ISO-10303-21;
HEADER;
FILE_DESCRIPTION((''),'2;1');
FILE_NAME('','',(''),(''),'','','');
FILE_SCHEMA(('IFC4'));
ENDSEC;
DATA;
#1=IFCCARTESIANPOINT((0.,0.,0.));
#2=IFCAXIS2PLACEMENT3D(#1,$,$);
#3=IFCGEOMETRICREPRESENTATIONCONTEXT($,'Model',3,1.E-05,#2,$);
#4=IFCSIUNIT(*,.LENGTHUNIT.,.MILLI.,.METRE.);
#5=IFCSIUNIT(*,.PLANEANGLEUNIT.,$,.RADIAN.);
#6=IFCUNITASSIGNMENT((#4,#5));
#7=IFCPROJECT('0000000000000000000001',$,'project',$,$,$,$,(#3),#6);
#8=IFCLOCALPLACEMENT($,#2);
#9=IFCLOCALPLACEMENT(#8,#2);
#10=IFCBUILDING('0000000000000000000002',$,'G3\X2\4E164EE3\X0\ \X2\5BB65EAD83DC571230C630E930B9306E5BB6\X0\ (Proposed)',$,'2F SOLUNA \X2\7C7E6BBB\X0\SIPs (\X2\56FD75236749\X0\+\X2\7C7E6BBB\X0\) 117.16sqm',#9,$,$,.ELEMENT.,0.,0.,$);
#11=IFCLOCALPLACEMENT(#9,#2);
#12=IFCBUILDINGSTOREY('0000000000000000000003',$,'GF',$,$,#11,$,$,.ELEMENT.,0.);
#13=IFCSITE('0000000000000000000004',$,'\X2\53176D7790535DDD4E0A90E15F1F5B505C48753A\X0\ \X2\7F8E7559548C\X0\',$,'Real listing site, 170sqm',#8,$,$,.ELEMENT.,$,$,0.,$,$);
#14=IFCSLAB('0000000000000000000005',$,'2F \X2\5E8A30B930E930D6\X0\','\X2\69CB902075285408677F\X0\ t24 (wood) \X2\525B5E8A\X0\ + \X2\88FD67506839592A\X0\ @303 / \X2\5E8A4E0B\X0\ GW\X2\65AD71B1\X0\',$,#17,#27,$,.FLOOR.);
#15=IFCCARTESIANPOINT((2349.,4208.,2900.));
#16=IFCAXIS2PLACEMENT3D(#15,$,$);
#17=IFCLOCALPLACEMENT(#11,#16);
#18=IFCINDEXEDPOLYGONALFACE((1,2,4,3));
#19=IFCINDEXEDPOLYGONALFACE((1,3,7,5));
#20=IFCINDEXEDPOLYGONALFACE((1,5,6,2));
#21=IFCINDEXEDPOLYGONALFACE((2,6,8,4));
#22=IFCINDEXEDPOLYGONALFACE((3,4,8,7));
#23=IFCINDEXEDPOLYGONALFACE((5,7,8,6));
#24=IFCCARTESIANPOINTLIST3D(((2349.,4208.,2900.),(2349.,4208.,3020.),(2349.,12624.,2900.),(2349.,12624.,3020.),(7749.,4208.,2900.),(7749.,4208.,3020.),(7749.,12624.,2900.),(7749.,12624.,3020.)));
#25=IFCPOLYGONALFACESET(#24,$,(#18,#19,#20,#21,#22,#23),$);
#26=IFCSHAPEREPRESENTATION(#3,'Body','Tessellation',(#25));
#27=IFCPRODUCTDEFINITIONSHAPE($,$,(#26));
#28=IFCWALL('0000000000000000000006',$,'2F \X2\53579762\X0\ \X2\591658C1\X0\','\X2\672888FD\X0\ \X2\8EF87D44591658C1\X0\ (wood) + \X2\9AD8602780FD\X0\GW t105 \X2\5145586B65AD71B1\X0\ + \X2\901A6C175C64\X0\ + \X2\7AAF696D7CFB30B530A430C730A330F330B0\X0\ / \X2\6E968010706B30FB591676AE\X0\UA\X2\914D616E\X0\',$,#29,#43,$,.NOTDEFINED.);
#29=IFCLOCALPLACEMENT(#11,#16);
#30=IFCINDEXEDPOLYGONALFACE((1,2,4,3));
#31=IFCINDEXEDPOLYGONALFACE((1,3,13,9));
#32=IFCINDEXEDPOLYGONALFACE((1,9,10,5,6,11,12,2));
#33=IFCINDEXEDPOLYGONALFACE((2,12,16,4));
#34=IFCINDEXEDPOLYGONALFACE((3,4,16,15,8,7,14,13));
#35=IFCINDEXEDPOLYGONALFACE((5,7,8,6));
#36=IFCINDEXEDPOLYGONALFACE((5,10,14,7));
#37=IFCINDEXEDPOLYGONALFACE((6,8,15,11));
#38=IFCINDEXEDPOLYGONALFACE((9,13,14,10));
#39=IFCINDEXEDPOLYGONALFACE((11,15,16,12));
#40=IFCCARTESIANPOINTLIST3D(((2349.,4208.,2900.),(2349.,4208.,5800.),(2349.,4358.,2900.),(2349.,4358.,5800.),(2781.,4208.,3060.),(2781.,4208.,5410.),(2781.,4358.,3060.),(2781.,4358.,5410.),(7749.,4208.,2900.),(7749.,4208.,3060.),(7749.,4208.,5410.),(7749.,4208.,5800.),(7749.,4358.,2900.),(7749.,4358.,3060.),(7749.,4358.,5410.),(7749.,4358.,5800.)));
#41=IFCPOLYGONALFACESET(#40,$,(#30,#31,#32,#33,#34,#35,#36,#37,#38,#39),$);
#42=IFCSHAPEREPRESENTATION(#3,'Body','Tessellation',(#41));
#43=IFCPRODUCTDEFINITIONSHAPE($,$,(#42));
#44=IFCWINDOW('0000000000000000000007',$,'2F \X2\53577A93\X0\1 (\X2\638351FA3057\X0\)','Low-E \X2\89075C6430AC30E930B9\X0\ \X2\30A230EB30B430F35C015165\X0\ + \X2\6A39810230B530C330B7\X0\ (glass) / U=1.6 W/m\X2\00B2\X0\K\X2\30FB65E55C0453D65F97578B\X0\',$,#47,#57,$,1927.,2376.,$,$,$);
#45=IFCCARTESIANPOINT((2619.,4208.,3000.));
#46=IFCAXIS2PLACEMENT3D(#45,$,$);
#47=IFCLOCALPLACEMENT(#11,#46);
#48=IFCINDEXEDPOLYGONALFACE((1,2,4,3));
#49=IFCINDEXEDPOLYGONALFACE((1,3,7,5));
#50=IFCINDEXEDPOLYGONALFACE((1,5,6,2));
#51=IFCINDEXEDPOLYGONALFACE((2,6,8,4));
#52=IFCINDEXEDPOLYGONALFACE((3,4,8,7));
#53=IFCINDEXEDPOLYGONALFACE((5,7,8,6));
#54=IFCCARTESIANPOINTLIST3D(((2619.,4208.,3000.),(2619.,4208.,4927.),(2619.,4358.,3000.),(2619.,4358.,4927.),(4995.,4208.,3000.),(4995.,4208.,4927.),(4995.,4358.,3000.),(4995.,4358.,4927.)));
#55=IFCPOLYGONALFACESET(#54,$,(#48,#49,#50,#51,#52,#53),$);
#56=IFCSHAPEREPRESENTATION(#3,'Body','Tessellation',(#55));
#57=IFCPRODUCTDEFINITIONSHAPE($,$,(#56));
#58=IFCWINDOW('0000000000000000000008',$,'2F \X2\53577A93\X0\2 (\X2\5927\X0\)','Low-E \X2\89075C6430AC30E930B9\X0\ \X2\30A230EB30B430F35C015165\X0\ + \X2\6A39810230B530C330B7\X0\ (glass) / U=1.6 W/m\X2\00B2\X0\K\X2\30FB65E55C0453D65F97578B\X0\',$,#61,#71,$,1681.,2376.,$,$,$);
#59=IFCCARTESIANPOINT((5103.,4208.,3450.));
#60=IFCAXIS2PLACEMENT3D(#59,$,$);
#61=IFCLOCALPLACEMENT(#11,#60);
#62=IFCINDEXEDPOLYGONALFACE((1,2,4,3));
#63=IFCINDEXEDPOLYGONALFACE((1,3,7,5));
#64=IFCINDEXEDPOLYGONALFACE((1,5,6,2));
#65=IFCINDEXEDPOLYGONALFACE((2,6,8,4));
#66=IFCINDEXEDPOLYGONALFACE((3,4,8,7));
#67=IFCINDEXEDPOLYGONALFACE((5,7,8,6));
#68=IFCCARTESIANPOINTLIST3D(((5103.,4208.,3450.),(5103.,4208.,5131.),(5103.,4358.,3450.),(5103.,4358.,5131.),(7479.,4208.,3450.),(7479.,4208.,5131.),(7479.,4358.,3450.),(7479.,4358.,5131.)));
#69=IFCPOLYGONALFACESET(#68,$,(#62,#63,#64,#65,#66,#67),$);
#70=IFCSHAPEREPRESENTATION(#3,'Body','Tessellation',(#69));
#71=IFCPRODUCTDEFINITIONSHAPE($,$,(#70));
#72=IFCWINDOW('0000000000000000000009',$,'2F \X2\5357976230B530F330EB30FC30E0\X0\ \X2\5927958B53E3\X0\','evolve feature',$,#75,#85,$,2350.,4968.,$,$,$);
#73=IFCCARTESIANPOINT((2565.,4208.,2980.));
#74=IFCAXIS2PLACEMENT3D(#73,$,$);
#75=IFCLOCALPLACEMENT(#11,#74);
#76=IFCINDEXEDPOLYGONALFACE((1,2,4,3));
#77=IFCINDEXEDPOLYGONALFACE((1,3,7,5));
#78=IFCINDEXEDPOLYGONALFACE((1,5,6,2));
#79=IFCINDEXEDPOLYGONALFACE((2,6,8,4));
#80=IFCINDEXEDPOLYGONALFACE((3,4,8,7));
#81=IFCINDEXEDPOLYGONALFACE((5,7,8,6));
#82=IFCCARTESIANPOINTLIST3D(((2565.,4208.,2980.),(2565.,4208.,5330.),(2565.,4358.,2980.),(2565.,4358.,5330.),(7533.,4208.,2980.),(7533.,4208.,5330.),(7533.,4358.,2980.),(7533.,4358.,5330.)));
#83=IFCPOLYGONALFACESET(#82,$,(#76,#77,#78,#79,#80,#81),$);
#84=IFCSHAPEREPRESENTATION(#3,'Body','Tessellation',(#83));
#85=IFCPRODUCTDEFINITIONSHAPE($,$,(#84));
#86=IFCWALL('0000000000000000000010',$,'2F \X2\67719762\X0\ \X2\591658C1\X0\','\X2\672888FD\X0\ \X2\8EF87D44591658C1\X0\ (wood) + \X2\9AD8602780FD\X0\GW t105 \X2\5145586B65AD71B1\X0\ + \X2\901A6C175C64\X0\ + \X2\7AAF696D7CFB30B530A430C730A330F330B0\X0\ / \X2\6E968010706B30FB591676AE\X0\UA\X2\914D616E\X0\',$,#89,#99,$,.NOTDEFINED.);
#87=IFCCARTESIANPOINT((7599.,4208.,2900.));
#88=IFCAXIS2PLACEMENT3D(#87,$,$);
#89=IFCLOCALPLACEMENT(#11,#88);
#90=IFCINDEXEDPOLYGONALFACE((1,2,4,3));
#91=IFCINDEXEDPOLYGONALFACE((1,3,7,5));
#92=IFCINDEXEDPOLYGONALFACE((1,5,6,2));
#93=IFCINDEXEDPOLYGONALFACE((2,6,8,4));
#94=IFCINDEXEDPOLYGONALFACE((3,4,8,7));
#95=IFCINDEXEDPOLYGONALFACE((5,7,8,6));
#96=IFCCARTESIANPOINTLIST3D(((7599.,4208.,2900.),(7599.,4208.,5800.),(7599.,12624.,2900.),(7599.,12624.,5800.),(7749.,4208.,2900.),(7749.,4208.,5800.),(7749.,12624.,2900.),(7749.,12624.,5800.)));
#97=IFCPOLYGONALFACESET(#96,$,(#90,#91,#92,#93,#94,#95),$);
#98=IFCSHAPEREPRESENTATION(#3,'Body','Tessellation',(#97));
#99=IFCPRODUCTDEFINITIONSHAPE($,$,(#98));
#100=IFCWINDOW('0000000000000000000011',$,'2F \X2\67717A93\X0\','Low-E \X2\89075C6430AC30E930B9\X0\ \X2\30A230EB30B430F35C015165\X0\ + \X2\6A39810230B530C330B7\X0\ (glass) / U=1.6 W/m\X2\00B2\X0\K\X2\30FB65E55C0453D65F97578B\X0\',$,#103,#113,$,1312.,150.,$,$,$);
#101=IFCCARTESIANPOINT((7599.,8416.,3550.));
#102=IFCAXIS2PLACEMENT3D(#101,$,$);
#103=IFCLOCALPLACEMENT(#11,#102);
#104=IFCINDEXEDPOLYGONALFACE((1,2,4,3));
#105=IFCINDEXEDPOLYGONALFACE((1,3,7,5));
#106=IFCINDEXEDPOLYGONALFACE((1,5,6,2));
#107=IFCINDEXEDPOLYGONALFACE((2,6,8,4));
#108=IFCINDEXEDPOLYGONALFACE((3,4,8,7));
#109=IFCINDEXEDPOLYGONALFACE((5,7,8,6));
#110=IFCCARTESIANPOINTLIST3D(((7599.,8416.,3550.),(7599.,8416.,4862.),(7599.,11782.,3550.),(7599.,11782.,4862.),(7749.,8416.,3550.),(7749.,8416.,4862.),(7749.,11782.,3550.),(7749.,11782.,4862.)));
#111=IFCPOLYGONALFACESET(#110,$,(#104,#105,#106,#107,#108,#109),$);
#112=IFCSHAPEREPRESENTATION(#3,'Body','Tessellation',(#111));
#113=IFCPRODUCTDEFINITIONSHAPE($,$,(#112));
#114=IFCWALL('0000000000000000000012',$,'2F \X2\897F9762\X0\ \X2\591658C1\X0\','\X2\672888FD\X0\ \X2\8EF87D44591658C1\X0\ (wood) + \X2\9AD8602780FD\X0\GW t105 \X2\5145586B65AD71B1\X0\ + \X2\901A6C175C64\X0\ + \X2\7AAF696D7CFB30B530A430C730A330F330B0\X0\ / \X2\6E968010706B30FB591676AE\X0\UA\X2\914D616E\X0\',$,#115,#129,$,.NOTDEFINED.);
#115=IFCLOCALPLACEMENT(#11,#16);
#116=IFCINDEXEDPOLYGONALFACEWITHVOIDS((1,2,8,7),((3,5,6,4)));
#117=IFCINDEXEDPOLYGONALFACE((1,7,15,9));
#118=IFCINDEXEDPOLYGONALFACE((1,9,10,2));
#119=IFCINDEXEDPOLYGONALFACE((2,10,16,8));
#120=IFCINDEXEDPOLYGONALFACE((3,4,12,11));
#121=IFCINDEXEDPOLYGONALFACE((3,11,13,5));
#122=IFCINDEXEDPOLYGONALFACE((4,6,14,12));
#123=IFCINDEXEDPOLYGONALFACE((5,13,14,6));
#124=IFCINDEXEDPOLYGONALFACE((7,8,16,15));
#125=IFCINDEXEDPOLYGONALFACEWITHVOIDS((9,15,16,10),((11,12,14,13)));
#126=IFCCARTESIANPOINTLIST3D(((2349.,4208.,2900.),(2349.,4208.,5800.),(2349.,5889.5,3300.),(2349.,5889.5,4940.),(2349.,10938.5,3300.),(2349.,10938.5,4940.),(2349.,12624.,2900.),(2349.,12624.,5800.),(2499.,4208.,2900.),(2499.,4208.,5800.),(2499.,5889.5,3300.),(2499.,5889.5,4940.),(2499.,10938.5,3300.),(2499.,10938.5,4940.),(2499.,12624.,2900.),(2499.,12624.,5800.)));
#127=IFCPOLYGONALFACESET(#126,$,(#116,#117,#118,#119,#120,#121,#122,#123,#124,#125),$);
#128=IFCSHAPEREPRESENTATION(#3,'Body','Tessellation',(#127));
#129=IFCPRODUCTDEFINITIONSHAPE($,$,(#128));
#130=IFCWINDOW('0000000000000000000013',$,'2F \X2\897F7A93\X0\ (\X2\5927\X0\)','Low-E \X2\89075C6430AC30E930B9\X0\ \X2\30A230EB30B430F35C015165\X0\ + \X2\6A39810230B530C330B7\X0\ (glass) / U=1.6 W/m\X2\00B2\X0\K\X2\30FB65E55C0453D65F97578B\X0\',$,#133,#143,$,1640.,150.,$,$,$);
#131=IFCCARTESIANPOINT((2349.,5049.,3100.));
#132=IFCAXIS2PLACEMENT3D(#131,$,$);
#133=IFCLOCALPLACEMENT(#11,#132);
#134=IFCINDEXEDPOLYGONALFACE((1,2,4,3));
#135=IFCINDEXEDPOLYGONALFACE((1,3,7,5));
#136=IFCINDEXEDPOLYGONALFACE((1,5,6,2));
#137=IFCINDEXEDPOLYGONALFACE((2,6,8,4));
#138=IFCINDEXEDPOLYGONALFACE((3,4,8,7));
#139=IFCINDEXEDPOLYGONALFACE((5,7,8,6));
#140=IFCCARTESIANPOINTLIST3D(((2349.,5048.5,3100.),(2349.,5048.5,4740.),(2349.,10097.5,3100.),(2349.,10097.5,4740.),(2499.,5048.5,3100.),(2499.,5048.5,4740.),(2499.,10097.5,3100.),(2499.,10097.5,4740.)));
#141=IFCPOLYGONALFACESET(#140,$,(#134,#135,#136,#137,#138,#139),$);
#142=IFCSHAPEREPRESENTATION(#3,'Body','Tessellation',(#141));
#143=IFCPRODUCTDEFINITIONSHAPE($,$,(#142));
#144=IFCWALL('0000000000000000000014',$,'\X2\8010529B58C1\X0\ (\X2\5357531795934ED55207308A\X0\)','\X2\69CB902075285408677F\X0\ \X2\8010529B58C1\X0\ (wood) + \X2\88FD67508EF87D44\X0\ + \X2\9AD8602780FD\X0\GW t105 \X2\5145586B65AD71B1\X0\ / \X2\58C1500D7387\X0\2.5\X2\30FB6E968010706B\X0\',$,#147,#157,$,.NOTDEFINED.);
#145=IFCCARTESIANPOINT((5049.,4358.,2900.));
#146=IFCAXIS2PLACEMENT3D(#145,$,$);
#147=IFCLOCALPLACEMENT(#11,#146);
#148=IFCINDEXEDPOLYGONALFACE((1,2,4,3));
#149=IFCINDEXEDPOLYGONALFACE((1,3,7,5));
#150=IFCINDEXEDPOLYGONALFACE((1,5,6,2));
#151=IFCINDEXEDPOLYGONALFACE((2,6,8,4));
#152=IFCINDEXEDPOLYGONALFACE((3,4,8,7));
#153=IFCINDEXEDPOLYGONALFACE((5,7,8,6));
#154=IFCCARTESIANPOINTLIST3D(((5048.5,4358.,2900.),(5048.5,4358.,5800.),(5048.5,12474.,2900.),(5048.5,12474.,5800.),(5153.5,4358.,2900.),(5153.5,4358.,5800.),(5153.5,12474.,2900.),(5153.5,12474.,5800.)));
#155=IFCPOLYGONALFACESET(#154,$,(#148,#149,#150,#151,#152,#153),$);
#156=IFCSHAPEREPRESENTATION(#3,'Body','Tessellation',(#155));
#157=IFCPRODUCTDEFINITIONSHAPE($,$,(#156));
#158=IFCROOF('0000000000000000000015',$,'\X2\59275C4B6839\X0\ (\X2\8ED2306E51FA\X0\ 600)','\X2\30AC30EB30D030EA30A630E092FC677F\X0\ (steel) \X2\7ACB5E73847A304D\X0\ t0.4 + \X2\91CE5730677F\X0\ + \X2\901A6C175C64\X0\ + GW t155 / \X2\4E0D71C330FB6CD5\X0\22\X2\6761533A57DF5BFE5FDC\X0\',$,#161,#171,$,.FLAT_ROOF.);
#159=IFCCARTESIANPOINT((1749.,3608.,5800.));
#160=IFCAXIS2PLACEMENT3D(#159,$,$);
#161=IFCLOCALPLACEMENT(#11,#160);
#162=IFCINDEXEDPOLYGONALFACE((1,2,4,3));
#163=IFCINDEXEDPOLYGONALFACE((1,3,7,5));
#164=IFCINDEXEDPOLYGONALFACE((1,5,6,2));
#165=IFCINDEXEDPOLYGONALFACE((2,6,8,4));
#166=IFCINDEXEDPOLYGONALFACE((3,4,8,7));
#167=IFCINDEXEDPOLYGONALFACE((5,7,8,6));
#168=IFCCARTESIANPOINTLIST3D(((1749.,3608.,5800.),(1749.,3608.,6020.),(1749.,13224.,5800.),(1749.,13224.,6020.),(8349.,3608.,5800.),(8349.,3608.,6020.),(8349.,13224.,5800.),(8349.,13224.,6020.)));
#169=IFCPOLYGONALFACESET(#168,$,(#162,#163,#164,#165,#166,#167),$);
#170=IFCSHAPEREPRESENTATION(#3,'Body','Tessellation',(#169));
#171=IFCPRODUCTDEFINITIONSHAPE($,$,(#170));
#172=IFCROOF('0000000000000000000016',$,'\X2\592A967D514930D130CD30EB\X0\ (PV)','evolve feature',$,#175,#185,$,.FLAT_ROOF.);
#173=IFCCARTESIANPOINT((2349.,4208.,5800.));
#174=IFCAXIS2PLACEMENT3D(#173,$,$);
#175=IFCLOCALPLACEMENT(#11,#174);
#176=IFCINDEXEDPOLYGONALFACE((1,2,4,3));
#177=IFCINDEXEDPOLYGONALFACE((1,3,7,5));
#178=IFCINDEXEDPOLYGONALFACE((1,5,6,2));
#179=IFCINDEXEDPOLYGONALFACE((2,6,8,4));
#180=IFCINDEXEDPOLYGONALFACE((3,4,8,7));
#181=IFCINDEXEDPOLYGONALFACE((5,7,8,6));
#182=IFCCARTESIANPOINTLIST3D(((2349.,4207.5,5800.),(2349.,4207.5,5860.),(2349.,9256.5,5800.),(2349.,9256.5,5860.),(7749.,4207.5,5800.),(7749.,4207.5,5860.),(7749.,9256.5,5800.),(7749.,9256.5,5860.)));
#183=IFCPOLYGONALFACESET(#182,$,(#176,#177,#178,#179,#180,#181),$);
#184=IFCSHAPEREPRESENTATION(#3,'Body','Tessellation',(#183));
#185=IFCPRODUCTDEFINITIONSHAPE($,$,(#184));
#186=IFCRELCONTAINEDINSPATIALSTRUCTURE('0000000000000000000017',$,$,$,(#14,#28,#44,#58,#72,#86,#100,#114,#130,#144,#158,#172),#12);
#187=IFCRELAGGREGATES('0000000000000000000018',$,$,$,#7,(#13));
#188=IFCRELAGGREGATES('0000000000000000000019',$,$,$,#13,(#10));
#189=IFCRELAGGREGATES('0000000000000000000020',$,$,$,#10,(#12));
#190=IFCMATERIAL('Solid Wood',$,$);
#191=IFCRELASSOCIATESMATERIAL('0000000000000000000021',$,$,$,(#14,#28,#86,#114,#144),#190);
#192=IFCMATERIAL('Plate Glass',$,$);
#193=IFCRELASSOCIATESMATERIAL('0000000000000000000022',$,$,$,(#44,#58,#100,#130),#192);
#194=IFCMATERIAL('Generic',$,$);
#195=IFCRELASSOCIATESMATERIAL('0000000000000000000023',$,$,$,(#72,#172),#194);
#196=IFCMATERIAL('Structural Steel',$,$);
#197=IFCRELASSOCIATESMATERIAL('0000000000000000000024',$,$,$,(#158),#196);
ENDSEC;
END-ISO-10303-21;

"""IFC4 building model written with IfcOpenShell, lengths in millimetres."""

from ifc_helpers import new_model, si_unit, frame, frame_2d, origin, place, context, project, spatial, rectangle, extrude, material, element, fill, save


model = new_model("IFC4")

# Units and contexts
model_context = context("Model", 3, precision=1e-05, world=origin())
ifc_project = project(units=[si_unit("LENGTHUNIT", "METRE", prefix="MILLI"), si_unit("PLANEANGLEUNIT", "RADIAN")], contexts=[model_context])

# Site, building, storey
site_placement = place(None, origin())
site = spatial("IfcSite", under=ifc_project, at=site_placement, Name="北海道川上郡弟子屈町 美留和", ObjectType="Real listing site, 170sqm", CompositionType="ELEMENT", RefElevation=0.0)
building_placement = place(site_placement, origin())
building = spatial("IfcBuilding", under=site, at=building_placement, Name="G3世代 家庭菜園テラスの家 (Proposed)", ObjectType="2F SOLUNA 籾殻SIPs (国産杉+籾殻) 117.16sqm", CompositionType="ELEMENT", ElevationOfRefHeight=0.0, ElevationOfTerrain=0.0)
storey_placement = place(building_placement, origin())
storey = spatial("IfcBuildingStorey", under=building, at=storey_placement, Name="GF", CompositionType="ELEMENT", Elevation=0.0)

# Slab
ifc_material_1 = material(Name="Solid Wood")
slab_placement = place(storey_placement, frame((2349.0, 4208.0, 2900.0)))
element("IfcSlab", 1, at=slab_placement, inside=storey, material=ifc_material_1, Name="2F 床スラブ", Description="構造用合板 t24 (wood) 剛床 + 製材根太 @303 / 床下 GW断熱", PredefinedType="FLOOR", context=model_context, shape_type="SweptSolid", body=[
    extrude(rectangle(XDim=5400.0, YDim=8416.0, at=frame_2d((2700.0, 4208.0))), frame((2349.0, 4208.0, 2900.0)), (0.0, 0.0, 1.0), 120.0),
])

# Wall, openings, windows
wall_1_placement = place(storey_placement, frame((2349.0, 4208.0, 2900.0)))
wall_1 = element("IfcWall", 2, at=wall_1_placement, inside=storey, material=ifc_material_1, Name="2F 南面 外壁", Description="木製 軸組外壁 (wood) + 高性能GW t105 充填断熱 + 通気層 + 窯業系サイディング / 準耐火・外皮UA配慮", PredefinedType="NOTDEFINED", context=model_context, shape_type="SweptSolid", body=[
    extrude(rectangle(XDim=5400.0, YDim=150.0, at=frame_2d((2700.0, 75.0))), frame((2349.0, 4208.0, 2900.0)), (0.0, 0.0, 1.0), 2900.0),
])
opening_1_placement = place(storey_placement, frame((2619.0, 4208.0, 3000.0)))
opening_1 = element("IfcOpeningElement", 3, at=opening_1_placement, cuts=wall_1, PredefinedType="NOTDEFINED", context=model_context, shape_type="SweptSolid", body=[
    extrude(rectangle(XDim=2376.0, YDim=150.0, at=frame_2d((1188.0, 75.0))), frame((2619.0, 4208.0, 3000.0)), (0.0, 0.0, 1.0), 1927.0),
])
opening_2_placement = place(storey_placement, frame((5103.0, 4208.0, 3450.0)))
opening_2 = element("IfcOpeningElement", 4, at=opening_2_placement, cuts=wall_1, PredefinedType="NOTDEFINED", context=model_context, shape_type="SweptSolid", body=[
    extrude(rectangle(XDim=2376.0, YDim=150.0, at=frame_2d((1188.0, 75.0))), frame((5103.0, 4208.0, 3450.0)), (0.0, 0.0, 1.0), 1681.0),
])
opening_3_placement = place(storey_placement, frame((2565.0, 4208.0, 2980.0)))
opening_3 = element("IfcOpeningElement", 5, at=opening_3_placement, cuts=wall_1, PredefinedType="NOTDEFINED", context=model_context, shape_type="SweptSolid", body=[
    extrude(rectangle(XDim=4968.0, YDim=150.0, at=frame_2d((2484.0, 75.0))), frame((2565.0, 4208.0, 2980.0)), (0.0, 0.0, 1.0), 2350.0),
])
ifc_material_2 = material(Name="Plate Glass")
window_1_placement = place(storey_placement, frame((2619.0, 4208.0, 3000.0)))
window_1 = element("IfcWindow", 6, at=window_1_placement, inside=storey, material=ifc_material_2, Name="2F 南窓1 (掃出し)", Description="Low-E 複層ガラス アルゴン封入 + 樹脂サッシ (glass) / U=1.6 W/m²K・日射取得型", OverallHeight=1927.0, OverallWidth=2376.0, context=model_context, shape_type="SweptSolid", body=[
    extrude(rectangle(XDim=2376.0, YDim=150.0, at=frame_2d((1188.0, 75.0))), frame((2619.0, 4208.0, 3000.0)), (0.0, 0.0, 1.0), 1927.0),
])
fill(opening_1, window_1)
window_2_placement = place(storey_placement, frame((5103.0, 4208.0, 3450.0)))
window_2 = element("IfcWindow", 7, at=window_2_placement, inside=storey, material=ifc_material_2, Name="2F 南窓2 (大)", Description="Low-E 複層ガラス アルゴン封入 + 樹脂サッシ (glass) / U=1.6 W/m²K・日射取得型", OverallHeight=1681.0, OverallWidth=2376.0, context=model_context, shape_type="SweptSolid", body=[
    extrude(rectangle(XDim=2376.0, YDim=150.0, at=frame_2d((1188.0, 75.0))), frame((5103.0, 4208.0, 3450.0)), (0.0, 0.0, 1.0), 1681.0),
])
fill(opening_2, window_2)
ifc_material_3 = material(Name="Generic")
window_3_placement = place(storey_placement, frame((2565.0, 4208.0, 2980.0)))
window_3 = element("IfcWindow", 8, at=window_3_placement, inside=storey, material=ifc_material_3, Name="2F 南面サンルーム 大開口", Description="evolve feature", OverallHeight=2350.0, OverallWidth=4968.0, context=model_context, shape_type="SweptSolid", body=[
    extrude(rectangle(XDim=4968.0, YDim=150.0, at=frame_2d((2484.0, 75.0))), frame((2565.0, 4208.0, 2980.0)), (0.0, 0.0, 1.0), 2350.0),
])
fill(opening_3, window_3)

# Walls, openings, windows
wall_2_placement = place(storey_placement, frame((7599.0, 4208.0, 2900.0)))
wall_2 = element("IfcWall", 9, at=wall_2_placement, inside=storey, material=ifc_material_1, Name="2F 東面 外壁", Description="木製 軸組外壁 (wood) + 高性能GW t105 充填断熱 + 通気層 + 窯業系サイディング / 準耐火・外皮UA配慮", PredefinedType="NOTDEFINED", context=model_context, shape_type="SweptSolid", body=[
    extrude(rectangle(XDim=150.0, YDim=8416.0, at=frame_2d((75.0, 4208.0))), frame((7599.0, 4208.0, 2900.0)), (0.0, 0.0, 1.0), 2900.0),
])
opening_4_placement = place(storey_placement, frame((7599.0, 8416.0, 3550.0)))
opening_4 = element("IfcOpeningElement", 10, at=opening_4_placement, cuts=wall_2, PredefinedType="NOTDEFINED", context=model_context, shape_type="SweptSolid", body=[
    extrude(rectangle(XDim=150.0, YDim=3366.0, at=frame_2d((75.0, 1683.0))), frame((7599.0, 8416.0, 3550.0)), (0.0, 0.0, 1.0), 1312.0),
])
window_4_placement = place(storey_placement, frame((7599.0, 8416.0, 3550.0)))
window_4 = element("IfcWindow", 11, at=window_4_placement, inside=storey, material=ifc_material_2, Name="2F 東窓", Description="Low-E 複層ガラス アルゴン封入 + 樹脂サッシ (glass) / U=1.6 W/m²K・日射取得型", OverallHeight=1312.0, OverallWidth=150.0, context=model_context, shape_type="SweptSolid", body=[
    extrude(rectangle(XDim=150.0, YDim=3366.0, at=frame_2d((75.0, 1683.0))), frame((7599.0, 8416.0, 3550.0)), (0.0, 0.0, 1.0), 1312.0),
])
fill(opening_4, window_4)
wall_3_placement = place(storey_placement, frame((2349.0, 4208.0, 2900.0)))
wall_3 = element("IfcWall", 12, at=wall_3_placement, inside=storey, material=ifc_material_1, Name="2F 西面 外壁", Description="木製 軸組外壁 (wood) + 高性能GW t105 充填断熱 + 通気層 + 窯業系サイディング / 準耐火・外皮UA配慮", PredefinedType="NOTDEFINED", context=model_context, shape_type="SweptSolid", body=[
    extrude(rectangle(XDim=150.0, YDim=8416.0, at=frame_2d((75.0, 4208.0))), frame((2349.0, 4208.0, 2900.0)), (0.0, 0.0, 1.0), 2900.0),
])
opening_5_placement = place(storey_placement, frame((2349.0, 5049.0, 3100.0)))
opening_5 = element("IfcOpeningElement", 13, at=opening_5_placement, cuts=wall_3, PredefinedType="NOTDEFINED", context=model_context, shape_type="SweptSolid", body=[
    extrude(rectangle(XDim=150.0, YDim=5049.0, at=frame_2d((75.0, 2524.0))), frame((2349.0, 5049.0, 3100.0)), (0.0, 0.0, 1.0), 1640.0),
])
window_5_placement = place(storey_placement, frame((2349.0, 5049.0, 3100.0)))
window_5 = element("IfcWindow", 14, at=window_5_placement, inside=storey, material=ifc_material_2, Name="2F 西窓 (大)", Description="Low-E 複層ガラス アルゴン封入 + 樹脂サッシ (glass) / U=1.6 W/m²K・日射取得型", OverallHeight=1640.0, OverallWidth=150.0, context=model_context, shape_type="SweptSolid", body=[
    extrude(rectangle(XDim=150.0, YDim=5049.0, at=frame_2d((75.0, 2524.0))), frame((2349.0, 5049.0, 3100.0)), (0.0, 0.0, 1.0), 1640.0),
])
fill(opening_5, window_5)

# Wall
wall_4_placement = place(storey_placement, frame((5049.0, 4358.0, 2900.0)))
element("IfcWall", 15, at=wall_4_placement, inside=storey, material=ifc_material_1, Name="耐力壁 (南北間仕切り)", Description="構造用合板 耐力壁 (wood) + 製材軸組 + 高性能GW t105 充填断熱 / 壁倍率2.5・準耐火", PredefinedType="NOTDEFINED", context=model_context, shape_type="SweptSolid", body=[
    extrude(rectangle(XDim=105.0, YDim=8116.0, at=frame_2d((52.0, 4058.0))), frame((5049.0, 4358.0, 2900.0)), (0.0, 0.0, 1.0), 2900.0),
])

# Roofs
ifc_material_4 = material(Name="Structural Steel")
roof_1_placement = place(storey_placement, frame((1749.0, 3608.0, 5800.0)))
element("IfcRoof", 16, at=roof_1_placement, inside=storey, material=ifc_material_4, Name="大屋根 (軒の出 600)", Description="ガルバリウム鋼板 (steel) 立平葺き t0.4 + 野地板 + 通気層 + GW t155 / 不燃・法22条区域対応", PredefinedType="FLAT_ROOF", context=model_context, shape_type="SweptSolid", body=[
    extrude(rectangle(XDim=6600.0, YDim=9616.0, at=frame_2d((3300.0, 4808.0))), frame((1749.0, 3608.0, 5800.0)), (0.0, 0.0, 1.0), 220.0),
])
roof_2_placement = place(storey_placement, frame((2349.0, 4208.0, 5800.0)))
element("IfcRoof", 17, at=roof_2_placement, inside=storey, material=ifc_material_3, Name="太陽光パネル (PV)", Description="evolve feature", PredefinedType="FLAT_ROOF", context=model_context, shape_type="SweptSolid", body=[
    extrude(rectangle(XDim=5400.0, YDim=5049.0, at=frame_2d((2700.0, 2524.0))), frame((2349.0, 4208.0, 5800.0)), (0.0, 0.0, 1.0), 60.0),
])

save(model, "model.ifc")
